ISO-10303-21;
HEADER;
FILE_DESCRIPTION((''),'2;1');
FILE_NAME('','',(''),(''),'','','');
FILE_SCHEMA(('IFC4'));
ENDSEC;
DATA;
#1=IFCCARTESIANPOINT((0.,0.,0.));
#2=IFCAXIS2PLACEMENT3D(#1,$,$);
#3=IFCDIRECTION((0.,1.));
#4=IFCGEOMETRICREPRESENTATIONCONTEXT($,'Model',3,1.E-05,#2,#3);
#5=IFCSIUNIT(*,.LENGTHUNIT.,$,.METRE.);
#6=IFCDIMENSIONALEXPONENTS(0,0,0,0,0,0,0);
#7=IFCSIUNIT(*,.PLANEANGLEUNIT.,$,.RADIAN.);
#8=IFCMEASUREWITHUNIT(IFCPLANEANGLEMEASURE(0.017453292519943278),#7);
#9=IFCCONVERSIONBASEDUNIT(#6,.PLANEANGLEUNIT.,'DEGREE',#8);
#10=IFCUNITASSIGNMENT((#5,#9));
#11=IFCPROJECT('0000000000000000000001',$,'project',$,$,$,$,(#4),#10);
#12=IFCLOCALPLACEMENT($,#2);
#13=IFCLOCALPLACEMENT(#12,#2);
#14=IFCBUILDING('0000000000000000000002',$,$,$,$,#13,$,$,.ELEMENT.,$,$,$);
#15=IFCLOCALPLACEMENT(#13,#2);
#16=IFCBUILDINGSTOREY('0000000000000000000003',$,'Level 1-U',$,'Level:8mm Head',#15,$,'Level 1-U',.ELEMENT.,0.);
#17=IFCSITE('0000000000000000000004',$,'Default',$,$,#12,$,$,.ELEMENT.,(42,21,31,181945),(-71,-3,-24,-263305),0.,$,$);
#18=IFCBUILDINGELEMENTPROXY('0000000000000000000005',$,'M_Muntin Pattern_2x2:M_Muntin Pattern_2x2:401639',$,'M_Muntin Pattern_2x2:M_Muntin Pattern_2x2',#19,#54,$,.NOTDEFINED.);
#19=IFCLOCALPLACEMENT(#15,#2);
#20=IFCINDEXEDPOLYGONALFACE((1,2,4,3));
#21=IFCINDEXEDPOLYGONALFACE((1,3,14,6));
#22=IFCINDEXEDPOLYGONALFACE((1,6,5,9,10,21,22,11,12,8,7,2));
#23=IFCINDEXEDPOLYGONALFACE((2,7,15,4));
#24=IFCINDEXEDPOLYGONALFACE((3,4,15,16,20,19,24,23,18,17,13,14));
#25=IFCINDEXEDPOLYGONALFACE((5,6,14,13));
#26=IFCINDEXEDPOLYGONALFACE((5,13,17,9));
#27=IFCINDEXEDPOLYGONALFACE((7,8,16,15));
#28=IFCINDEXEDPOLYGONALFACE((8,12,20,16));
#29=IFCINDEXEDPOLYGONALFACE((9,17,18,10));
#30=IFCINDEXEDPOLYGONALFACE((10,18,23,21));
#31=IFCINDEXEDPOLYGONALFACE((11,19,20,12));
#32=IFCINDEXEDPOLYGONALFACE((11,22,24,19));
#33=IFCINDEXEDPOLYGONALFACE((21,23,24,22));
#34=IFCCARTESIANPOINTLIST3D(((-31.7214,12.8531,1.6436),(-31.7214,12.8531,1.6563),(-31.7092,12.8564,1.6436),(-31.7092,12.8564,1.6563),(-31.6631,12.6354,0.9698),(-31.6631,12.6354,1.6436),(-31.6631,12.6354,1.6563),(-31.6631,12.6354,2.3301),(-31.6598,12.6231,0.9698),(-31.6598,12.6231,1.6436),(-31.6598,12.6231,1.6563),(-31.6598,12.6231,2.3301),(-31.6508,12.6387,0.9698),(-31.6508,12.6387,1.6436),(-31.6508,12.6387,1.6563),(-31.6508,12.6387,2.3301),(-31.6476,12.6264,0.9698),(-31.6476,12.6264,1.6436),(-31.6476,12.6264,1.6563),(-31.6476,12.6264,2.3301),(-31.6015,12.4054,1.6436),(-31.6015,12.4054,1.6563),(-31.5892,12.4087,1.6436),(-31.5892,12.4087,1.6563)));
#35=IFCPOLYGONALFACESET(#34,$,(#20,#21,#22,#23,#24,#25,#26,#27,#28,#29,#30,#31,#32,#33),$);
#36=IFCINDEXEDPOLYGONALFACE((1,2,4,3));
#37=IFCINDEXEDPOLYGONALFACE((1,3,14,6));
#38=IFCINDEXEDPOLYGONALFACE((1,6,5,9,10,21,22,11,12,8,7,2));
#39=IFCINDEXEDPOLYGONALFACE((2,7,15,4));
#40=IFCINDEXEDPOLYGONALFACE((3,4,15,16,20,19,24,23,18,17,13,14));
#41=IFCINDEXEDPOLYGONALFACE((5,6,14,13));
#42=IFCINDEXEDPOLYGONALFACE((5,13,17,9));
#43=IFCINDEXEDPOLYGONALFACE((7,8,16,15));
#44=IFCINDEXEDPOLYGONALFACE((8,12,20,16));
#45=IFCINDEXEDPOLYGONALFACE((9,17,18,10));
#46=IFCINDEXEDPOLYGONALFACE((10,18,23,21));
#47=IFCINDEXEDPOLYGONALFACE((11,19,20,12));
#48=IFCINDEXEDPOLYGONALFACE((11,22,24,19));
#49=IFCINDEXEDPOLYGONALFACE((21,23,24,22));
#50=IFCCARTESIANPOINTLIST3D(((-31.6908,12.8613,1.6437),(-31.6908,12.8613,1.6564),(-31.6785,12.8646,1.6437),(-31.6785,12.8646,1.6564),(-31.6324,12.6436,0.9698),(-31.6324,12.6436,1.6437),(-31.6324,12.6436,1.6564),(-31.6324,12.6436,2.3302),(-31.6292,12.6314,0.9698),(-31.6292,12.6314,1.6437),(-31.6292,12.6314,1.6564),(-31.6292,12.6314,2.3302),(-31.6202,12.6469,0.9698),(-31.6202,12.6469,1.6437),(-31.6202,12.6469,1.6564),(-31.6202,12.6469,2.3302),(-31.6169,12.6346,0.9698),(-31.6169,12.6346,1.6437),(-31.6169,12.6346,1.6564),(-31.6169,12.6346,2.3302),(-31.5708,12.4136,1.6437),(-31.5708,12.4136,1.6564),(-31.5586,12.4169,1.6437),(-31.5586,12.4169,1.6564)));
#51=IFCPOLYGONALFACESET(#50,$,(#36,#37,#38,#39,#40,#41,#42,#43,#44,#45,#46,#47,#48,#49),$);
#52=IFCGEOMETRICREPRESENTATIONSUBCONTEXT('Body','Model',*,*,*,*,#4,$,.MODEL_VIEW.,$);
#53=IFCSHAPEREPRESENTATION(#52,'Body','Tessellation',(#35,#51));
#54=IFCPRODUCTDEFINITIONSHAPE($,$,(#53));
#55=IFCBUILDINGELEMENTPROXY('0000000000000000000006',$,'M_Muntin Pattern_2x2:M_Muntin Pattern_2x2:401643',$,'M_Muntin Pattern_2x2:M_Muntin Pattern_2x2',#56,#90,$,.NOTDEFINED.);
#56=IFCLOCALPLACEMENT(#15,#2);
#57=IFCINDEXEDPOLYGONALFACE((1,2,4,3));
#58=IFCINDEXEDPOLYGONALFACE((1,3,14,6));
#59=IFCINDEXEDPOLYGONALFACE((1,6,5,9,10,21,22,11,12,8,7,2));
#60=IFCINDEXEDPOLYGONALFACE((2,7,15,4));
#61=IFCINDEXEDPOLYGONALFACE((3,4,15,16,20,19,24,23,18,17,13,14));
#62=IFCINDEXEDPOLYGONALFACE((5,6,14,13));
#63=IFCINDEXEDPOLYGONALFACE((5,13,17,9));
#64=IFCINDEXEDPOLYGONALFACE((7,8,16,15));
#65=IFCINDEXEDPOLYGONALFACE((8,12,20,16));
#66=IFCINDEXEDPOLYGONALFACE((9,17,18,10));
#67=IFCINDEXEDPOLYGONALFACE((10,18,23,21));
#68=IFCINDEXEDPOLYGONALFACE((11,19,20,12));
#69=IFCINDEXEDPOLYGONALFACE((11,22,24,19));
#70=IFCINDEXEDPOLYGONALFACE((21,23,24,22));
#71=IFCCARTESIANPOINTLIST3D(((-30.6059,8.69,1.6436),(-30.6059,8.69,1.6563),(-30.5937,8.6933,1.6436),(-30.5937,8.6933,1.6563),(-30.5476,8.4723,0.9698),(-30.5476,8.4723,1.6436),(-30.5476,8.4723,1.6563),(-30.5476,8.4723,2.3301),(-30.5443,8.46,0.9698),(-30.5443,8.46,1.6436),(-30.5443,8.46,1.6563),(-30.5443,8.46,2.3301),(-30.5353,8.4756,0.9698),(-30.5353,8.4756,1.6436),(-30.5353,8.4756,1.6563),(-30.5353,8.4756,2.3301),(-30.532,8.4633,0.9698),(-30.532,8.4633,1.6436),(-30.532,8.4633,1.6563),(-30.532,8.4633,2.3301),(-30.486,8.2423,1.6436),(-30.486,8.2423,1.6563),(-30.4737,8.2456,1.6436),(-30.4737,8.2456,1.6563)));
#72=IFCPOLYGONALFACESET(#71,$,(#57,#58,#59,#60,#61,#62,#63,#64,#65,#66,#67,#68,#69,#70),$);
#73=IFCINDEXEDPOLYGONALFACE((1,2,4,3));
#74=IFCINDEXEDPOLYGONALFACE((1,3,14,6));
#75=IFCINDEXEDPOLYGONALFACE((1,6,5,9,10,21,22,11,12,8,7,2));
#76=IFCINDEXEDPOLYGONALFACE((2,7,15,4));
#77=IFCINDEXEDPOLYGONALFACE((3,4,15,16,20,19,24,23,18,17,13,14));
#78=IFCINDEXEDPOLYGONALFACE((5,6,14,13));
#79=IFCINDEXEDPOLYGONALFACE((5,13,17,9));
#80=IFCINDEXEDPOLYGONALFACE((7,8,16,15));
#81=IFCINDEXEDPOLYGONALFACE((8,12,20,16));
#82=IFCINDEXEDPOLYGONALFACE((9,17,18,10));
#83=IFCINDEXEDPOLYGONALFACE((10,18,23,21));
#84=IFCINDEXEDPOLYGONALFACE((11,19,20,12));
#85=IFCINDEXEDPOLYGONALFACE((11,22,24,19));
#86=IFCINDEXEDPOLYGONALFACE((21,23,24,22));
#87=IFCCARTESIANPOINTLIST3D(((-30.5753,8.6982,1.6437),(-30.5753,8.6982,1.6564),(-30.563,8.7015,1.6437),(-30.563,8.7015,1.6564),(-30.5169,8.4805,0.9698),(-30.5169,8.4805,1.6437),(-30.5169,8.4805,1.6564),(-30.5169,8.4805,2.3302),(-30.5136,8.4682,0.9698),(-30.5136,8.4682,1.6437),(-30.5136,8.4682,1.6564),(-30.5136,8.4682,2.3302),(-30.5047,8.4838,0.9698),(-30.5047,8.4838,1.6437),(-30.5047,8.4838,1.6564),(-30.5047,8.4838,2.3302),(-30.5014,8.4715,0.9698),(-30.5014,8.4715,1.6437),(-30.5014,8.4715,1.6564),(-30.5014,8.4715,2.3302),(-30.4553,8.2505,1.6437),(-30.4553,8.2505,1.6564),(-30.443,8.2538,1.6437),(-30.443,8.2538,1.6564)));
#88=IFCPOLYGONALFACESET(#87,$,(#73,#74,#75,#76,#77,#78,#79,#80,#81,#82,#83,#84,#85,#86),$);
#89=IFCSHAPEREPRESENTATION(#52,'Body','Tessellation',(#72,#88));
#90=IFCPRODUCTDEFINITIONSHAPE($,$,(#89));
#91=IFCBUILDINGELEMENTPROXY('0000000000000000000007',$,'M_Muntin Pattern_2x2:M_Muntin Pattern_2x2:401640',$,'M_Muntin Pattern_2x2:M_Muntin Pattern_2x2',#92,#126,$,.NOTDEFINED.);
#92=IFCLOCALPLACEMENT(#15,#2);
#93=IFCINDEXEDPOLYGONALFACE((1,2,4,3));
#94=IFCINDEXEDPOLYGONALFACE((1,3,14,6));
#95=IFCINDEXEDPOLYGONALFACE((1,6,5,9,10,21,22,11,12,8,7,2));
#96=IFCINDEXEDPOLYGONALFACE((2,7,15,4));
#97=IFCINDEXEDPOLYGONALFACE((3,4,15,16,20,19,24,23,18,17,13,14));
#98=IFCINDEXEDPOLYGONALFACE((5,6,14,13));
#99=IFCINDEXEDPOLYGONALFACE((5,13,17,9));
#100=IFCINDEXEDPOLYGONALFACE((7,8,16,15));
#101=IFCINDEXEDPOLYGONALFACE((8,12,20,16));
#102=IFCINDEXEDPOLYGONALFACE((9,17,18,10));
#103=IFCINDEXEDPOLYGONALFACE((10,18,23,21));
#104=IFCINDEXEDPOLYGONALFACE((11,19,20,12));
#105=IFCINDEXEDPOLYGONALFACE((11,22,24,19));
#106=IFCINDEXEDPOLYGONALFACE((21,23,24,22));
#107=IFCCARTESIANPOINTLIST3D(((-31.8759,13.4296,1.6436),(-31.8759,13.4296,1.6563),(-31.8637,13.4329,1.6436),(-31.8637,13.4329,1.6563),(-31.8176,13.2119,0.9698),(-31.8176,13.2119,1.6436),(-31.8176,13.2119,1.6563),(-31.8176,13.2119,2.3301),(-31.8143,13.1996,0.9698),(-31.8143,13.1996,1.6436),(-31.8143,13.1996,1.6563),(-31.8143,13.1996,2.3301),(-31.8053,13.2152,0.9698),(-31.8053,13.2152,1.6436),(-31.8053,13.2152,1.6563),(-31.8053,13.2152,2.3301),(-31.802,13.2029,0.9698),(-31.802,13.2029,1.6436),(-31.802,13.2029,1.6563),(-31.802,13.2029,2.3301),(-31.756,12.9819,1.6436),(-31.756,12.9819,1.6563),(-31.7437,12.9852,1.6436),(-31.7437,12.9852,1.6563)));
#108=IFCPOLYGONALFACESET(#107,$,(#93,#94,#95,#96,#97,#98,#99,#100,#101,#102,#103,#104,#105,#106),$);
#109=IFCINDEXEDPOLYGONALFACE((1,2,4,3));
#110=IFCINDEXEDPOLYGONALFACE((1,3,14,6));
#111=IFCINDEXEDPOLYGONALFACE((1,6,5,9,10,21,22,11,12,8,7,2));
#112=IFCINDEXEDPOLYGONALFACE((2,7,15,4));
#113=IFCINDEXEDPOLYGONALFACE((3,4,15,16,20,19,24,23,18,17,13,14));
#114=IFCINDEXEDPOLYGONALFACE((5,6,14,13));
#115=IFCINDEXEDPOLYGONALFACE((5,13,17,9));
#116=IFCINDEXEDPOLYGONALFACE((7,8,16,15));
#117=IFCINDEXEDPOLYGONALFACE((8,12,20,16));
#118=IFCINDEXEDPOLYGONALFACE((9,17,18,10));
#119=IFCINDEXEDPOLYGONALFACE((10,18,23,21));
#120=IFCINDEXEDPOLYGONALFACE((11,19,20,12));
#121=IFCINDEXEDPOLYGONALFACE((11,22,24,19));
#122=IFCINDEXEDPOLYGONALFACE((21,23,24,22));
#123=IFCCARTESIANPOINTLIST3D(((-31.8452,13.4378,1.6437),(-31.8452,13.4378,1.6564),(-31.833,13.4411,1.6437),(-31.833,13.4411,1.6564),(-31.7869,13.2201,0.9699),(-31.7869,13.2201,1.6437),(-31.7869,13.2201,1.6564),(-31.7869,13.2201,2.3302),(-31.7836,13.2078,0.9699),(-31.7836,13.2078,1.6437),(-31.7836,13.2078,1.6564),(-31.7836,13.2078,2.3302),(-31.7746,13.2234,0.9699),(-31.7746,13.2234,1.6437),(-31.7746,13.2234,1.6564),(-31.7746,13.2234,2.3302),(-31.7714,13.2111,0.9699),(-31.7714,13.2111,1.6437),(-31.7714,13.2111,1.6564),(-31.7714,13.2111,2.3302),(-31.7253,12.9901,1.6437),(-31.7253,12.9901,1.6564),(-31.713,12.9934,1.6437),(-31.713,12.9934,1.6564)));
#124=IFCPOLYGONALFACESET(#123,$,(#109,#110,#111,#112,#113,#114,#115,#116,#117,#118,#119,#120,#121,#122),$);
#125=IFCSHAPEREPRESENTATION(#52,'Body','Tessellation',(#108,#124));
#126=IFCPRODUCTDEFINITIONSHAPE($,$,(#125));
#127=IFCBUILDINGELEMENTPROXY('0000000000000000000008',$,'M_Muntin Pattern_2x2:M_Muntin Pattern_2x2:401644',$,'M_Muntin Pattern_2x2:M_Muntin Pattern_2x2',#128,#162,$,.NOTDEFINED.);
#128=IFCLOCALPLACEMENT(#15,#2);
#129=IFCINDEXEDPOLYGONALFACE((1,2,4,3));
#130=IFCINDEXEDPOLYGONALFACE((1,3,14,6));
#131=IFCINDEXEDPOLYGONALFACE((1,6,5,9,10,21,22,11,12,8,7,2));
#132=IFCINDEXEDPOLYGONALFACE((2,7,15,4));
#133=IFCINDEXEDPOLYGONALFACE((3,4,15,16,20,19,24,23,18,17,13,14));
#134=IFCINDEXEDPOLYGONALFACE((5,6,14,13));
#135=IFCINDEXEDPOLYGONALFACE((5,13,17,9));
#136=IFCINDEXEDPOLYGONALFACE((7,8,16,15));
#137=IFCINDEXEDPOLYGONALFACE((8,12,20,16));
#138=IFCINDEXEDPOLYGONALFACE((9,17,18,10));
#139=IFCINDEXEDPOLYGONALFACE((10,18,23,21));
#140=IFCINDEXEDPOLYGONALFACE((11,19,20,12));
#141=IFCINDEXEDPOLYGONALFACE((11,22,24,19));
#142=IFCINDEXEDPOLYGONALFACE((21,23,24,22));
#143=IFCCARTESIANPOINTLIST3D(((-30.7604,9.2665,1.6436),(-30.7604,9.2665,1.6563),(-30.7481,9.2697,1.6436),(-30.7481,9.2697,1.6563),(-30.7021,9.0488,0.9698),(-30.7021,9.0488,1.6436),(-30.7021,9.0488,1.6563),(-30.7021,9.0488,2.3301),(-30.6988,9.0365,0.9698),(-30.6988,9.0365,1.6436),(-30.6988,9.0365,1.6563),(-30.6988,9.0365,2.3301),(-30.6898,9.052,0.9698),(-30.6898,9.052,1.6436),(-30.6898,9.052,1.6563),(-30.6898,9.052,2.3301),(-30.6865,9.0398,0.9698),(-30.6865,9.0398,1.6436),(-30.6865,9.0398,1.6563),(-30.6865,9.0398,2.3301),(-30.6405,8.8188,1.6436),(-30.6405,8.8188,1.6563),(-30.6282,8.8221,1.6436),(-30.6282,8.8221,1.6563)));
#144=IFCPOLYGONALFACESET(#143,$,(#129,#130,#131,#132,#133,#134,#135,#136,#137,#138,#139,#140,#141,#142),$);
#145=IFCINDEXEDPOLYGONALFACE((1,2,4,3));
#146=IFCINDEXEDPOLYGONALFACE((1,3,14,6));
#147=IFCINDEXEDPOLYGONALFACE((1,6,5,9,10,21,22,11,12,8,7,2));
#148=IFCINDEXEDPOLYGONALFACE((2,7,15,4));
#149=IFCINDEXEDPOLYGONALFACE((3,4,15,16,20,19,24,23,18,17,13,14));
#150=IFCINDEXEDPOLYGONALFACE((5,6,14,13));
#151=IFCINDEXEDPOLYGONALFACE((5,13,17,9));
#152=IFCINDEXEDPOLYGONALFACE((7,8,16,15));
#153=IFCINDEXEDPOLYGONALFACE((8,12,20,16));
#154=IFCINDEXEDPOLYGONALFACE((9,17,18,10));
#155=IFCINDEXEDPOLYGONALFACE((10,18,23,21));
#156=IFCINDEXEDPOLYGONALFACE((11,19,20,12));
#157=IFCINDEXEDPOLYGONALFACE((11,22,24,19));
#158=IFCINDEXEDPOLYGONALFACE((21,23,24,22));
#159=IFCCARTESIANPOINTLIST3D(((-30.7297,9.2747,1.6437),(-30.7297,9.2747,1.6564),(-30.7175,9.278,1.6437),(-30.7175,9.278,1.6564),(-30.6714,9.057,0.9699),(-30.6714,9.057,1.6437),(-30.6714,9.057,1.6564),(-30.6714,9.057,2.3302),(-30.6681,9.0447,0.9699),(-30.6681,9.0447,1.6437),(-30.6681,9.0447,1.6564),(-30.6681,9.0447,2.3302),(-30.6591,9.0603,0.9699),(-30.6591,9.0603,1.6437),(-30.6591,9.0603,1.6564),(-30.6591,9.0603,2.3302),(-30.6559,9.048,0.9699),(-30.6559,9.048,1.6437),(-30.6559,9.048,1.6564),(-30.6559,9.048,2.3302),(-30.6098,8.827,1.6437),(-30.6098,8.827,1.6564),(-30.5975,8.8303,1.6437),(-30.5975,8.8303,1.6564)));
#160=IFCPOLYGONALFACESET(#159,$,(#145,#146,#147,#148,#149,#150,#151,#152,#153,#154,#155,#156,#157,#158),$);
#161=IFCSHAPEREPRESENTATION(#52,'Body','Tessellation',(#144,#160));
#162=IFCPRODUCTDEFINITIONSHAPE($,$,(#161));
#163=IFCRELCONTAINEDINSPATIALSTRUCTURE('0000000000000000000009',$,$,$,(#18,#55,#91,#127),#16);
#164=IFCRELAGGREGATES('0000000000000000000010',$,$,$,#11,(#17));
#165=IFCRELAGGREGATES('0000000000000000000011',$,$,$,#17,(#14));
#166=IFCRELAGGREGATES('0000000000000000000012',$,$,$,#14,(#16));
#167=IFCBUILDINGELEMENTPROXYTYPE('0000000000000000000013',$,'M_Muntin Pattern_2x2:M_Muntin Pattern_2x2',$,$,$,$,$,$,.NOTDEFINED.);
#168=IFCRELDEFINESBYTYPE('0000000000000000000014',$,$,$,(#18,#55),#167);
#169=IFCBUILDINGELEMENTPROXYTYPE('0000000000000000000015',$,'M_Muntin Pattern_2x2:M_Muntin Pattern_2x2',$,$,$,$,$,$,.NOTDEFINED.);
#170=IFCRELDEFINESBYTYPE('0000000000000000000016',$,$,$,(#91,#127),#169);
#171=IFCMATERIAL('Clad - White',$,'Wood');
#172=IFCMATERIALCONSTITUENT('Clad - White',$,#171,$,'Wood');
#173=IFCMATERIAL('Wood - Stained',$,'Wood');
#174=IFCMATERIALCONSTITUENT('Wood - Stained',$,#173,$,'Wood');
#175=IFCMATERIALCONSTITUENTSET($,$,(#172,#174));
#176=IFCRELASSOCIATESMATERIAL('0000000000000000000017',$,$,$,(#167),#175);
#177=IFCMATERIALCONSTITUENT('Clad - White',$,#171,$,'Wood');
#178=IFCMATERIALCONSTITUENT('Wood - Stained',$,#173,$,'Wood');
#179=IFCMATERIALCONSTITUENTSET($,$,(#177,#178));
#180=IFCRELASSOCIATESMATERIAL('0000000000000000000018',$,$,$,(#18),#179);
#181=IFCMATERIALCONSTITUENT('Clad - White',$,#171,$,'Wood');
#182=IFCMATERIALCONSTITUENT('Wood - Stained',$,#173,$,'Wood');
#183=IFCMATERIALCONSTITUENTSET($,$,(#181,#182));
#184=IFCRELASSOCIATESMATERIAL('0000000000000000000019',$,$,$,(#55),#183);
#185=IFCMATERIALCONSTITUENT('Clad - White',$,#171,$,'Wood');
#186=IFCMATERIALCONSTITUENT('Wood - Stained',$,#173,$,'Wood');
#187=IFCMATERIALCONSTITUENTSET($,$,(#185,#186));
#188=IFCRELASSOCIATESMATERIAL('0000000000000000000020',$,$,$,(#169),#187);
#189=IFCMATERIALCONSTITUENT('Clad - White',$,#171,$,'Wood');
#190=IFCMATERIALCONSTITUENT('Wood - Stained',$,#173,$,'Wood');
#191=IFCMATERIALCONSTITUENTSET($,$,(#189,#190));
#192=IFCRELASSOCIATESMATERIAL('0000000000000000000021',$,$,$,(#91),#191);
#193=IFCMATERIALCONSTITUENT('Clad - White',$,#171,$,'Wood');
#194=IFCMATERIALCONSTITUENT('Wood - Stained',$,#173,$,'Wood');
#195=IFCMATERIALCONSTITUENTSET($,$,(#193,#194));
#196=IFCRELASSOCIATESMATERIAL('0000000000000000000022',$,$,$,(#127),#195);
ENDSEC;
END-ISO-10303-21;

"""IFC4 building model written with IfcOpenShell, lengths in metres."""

from ifc_helpers import new_model, entity, si_unit, converted_unit, direction, frame, origin, place, context, subcontext, project, spatial, polyline, outline, extrude, source, transform, mapped, material, constituent, constituent_set, type_object, type_shapes, element, save


model = new_model("IFC4")

# Units and contexts
model_context = context("Model", 3, precision=1e-05, world=origin(), true_north=direction((0.0, 1.0)))
body_context = subcontext(model_context, "Body", "Model", "MODEL_VIEW")
ifc_project = project(units=[si_unit("LENGTHUNIT", "METRE"), converted_unit("PLANEANGLEUNIT", "DEGREE", entity("IfcPlaneAngleMeasure", 0.017453292519943278), si_unit("PLANEANGLEUNIT", "RADIAN"), dimensions=[0, 0, 0, 0, 0, 0, 0])], contexts=[model_context])

# Site, building, storey
site_placement = place(None, origin())
site = spatial("IfcSite", under=ifc_project, at=site_placement, Name="Default", CompositionType="ELEMENT", RefLatitude=(42, 21, 31, 181945), RefLongitude=(-71, -3, -24, -263305), RefElevation=0.0)
building_placement = place(site_placement, origin())
building = spatial("IfcBuilding", under=site, at=building_placement, CompositionType="ELEMENT")
storey_placement = place(building_placement, origin())
storey = spatial("IfcBuildingStorey", under=building, at=storey_placement, Name="Level 1-U", ObjectType="Level:8mm Head", LongName="Level 1-U", CompositionType="ELEMENT", Elevation=0.0)

# Building element proxies
ifc_material_1 = material(Name="Clad - White", Category="Wood")
ifc_constituent_1 = constituent(ifc_material_1, Name="Clad - White", Category="Wood")
ifc_material_2 = material(Name="Wood - Stained", Category="Wood")
ifc_constituent_2 = constituent(ifc_material_2, Name="Wood - Stained", Category="Wood")
ifc_constituent_set_1 = constituent_set(constituents=[ifc_constituent_1, ifc_constituent_2])
ifc_constituent_3 = constituent(ifc_material_1, Name="Clad - White", Category="Wood")
ifc_constituent_4 = constituent(ifc_material_2, Name="Wood - Stained", Category="Wood")
ifc_constituent_set_2 = constituent_set(constituents=[ifc_constituent_3, ifc_constituent_4])
building_element_proxy_type_1 = type_object("IfcBuildingElementProxyType", Name="M_Muntin Pattern_2x2:M_Muntin Pattern_2x2", PredefinedType="NOTDEFINED", material=ifc_constituent_set_2)
shared_shape_1 = source(origin(), body_context, "Body", "SweptSolid", [
    extrude(outline(polyline([(0.0064, -0.0064), (0.6801, -0.0064), (0.6801, 0.0063), (0.0064, 0.0063), (0.0064, 0.2317), (-0.0063, 0.2317), (-0.0063, 0.0063), (-0.6802, 0.0063), (-0.6802, -0.0064), (-0.0063, -0.0064), (-0.0063, -0.2317), (0.0064, -0.2317), (0.0064, -0.0064)])), frame((0.0, 0.0095, 0.6801), z_axis=(0.0, 1.0, 0.0), x_axis=(0.0, 0.0, 1.0)), (0.0, 0.0, 1.0), 0.0127),
    extrude(outline(polyline([(0.0064, -0.0064), (0.6802, -0.0064), (0.6802, 0.0063), (0.0064, 0.0063), (0.0064, 0.2317), (-0.0063, 0.2317), (-0.0063, 0.0063), (-0.6802, 0.0063), (-0.6802, -0.0064), (-0.0063, -0.0064), (-0.0063, -0.2317), (0.0064, -0.2317), (0.0064, -0.0064)])), frame((0.0, -0.0222, 0.6802), z_axis=(0.0, 1.0, 0.0), x_axis=(0.0, 0.0, 1.0)), (0.0, 0.0, 1.0), 0.0127),
])
type_shapes(building_element_proxy_type_1, [shared_shape_1])
proxy_1_placement = place(storey_placement, frame((-31.64, 12.635, 0.9698), z_axis=(0.0, 0.0, 1.0), x_axis=(-0.258819, 0.965926, 0.0)))
element("IfcBuildingElementProxy", 1, at=proxy_1_placement, inside=storey, type_object=building_element_proxy_type_1, material=ifc_constituent_set_1, Name="M_Muntin Pattern_2x2:M_Muntin Pattern_2x2:401639", ObjectType="M_Muntin Pattern_2x2:M_Muntin Pattern_2x2", PredefinedType="NOTDEFINED", context=body_context, shape_type="MappedRepresentation", body=[
    mapped(shared_shape_1, transform((0.0, 0.0, 0.0), scale=1.0)),
])
ifc_constituent_5 = constituent(ifc_material_1, Name="Clad - White", Category="Wood")
ifc_constituent_6 = constituent(ifc_material_2, Name="Wood - Stained", Category="Wood")
ifc_constituent_set_3 = constituent_set(constituents=[ifc_constituent_5, ifc_constituent_6])
proxy_2_placement = place(storey_placement, frame((-30.5245, 8.4719, 0.9698), z_axis=(0.0, 0.0, 1.0), x_axis=(-0.258819, 0.965926, 0.0)))
element("IfcBuildingElementProxy", 2, at=proxy_2_placement, inside=storey, type_object=building_element_proxy_type_1, material=ifc_constituent_set_3, Name="M_Muntin Pattern_2x2:M_Muntin Pattern_2x2:401643", ObjectType="M_Muntin Pattern_2x2:M_Muntin Pattern_2x2", PredefinedType="NOTDEFINED", context=body_context, shape_type="MappedRepresentation", body=[
    mapped(shared_shape_1, transform((0.0, 0.0, 0.0), scale=1.0)),
])
ifc_constituent_7 = constituent(ifc_material_1, Name="Clad - White", Category="Wood")
ifc_constituent_8 = constituent(ifc_material_2, Name="Wood - Stained", Category="Wood")
ifc_constituent_set_4 = constituent_set(constituents=[ifc_constituent_7, ifc_constituent_8])
ifc_constituent_9 = constituent(ifc_material_1, Name="Clad - White", Category="Wood")
ifc_constituent_10 = constituent(ifc_material_2, Name="Wood - Stained", Category="Wood")
ifc_constituent_set_5 = constituent_set(constituents=[ifc_constituent_9, ifc_constituent_10])
building_element_proxy_type_2 = type_object("IfcBuildingElementProxyType", Name="M_Muntin Pattern_2x2:M_Muntin Pattern_2x2", PredefinedType="NOTDEFINED", material=ifc_constituent_set_5)
shared_shape_2 = source(origin(), body_context, "Body", "SweptSolid", [
    extrude(outline(polyline([(0.0064, -0.0064), (0.6801, -0.0064), (0.6801, 0.0063), (0.0064, 0.0063), (0.0064, 0.2317), (-0.0063, 0.2317), (-0.0063, 0.0063), (-0.6802, 0.0063), (-0.6802, -0.0064), (-0.0063, -0.0064), (-0.0063, -0.2317), (0.0064, -0.2317), (0.0064, -0.0064)])), frame((0.0, -0.0222, 0.6801), z_axis=(0.0, 1.0, 0.0), x_axis=(0.0, 0.0, 1.0)), (0.0, 0.0, 1.0), 0.0127),
    extrude(outline(polyline([(0.0064, -0.0064), (0.6802, -0.0064), (0.6802, 0.0063), (0.0064, 0.0063), (0.0064, 0.2317), (-0.0063, 0.2317), (-0.0063, 0.0063), (-0.6802, 0.0063), (-0.6802, -0.0064), (-0.0063, -0.0064), (-0.0063, -0.2317), (0.0064, -0.2317), (0.0064, -0.0064)])), frame((0.0, 0.0095, 0.6802), z_axis=(0.0, 1.0, 0.0), x_axis=(0.0, 0.0, 1.0)), (0.0, 0.0, 1.0), 0.0127),
])
type_shapes(building_element_proxy_type_2, [shared_shape_2])
proxy_3_placement = place(storey_placement, frame((-31.7945, 13.2115, 0.9699), z_axis=(0.0, 0.0, 1.0), x_axis=(0.258819, -0.965926, 0.0)))
element("IfcBuildingElementProxy", 3, at=proxy_3_placement, inside=storey, type_object=building_element_proxy_type_2, material=ifc_constituent_set_4, Name="M_Muntin Pattern_2x2:M_Muntin Pattern_2x2:401640", ObjectType="M_Muntin Pattern_2x2:M_Muntin Pattern_2x2", PredefinedType="NOTDEFINED", context=body_context, shape_type="MappedRepresentation", body=[
    mapped(shared_shape_2, transform((0.0, 0.0, 0.0), scale=1.0)),
])
ifc_constituent_11 = constituent(ifc_material_1, Name="Clad - White", Category="Wood")
ifc_constituent_12 = constituent(ifc_material_2, Name="Wood - Stained", Category="Wood")
ifc_constituent_set_6 = constituent_set(constituents=[ifc_constituent_11, ifc_constituent_12])
proxy_4_placement = place(storey_placement, frame((-30.679, 9.0484, 0.9699), z_axis=(0.0, 0.0, 1.0), x_axis=(0.258819, -0.965926, 0.0)))
element("IfcBuildingElementProxy", 4, at=proxy_4_placement, inside=storey, type_object=building_element_proxy_type_2, material=ifc_constituent_set_6, Name="M_Muntin Pattern_2x2:M_Muntin Pattern_2x2:401644", ObjectType="M_Muntin Pattern_2x2:M_Muntin Pattern_2x2", PredefinedType="NOTDEFINED", context=body_context, shape_type="MappedRepresentation", body=[
    mapped(shared_shape_2, transform((0.0, 0.0, 0.0), scale=1.0)),
])

save(model, "model.ifc")
